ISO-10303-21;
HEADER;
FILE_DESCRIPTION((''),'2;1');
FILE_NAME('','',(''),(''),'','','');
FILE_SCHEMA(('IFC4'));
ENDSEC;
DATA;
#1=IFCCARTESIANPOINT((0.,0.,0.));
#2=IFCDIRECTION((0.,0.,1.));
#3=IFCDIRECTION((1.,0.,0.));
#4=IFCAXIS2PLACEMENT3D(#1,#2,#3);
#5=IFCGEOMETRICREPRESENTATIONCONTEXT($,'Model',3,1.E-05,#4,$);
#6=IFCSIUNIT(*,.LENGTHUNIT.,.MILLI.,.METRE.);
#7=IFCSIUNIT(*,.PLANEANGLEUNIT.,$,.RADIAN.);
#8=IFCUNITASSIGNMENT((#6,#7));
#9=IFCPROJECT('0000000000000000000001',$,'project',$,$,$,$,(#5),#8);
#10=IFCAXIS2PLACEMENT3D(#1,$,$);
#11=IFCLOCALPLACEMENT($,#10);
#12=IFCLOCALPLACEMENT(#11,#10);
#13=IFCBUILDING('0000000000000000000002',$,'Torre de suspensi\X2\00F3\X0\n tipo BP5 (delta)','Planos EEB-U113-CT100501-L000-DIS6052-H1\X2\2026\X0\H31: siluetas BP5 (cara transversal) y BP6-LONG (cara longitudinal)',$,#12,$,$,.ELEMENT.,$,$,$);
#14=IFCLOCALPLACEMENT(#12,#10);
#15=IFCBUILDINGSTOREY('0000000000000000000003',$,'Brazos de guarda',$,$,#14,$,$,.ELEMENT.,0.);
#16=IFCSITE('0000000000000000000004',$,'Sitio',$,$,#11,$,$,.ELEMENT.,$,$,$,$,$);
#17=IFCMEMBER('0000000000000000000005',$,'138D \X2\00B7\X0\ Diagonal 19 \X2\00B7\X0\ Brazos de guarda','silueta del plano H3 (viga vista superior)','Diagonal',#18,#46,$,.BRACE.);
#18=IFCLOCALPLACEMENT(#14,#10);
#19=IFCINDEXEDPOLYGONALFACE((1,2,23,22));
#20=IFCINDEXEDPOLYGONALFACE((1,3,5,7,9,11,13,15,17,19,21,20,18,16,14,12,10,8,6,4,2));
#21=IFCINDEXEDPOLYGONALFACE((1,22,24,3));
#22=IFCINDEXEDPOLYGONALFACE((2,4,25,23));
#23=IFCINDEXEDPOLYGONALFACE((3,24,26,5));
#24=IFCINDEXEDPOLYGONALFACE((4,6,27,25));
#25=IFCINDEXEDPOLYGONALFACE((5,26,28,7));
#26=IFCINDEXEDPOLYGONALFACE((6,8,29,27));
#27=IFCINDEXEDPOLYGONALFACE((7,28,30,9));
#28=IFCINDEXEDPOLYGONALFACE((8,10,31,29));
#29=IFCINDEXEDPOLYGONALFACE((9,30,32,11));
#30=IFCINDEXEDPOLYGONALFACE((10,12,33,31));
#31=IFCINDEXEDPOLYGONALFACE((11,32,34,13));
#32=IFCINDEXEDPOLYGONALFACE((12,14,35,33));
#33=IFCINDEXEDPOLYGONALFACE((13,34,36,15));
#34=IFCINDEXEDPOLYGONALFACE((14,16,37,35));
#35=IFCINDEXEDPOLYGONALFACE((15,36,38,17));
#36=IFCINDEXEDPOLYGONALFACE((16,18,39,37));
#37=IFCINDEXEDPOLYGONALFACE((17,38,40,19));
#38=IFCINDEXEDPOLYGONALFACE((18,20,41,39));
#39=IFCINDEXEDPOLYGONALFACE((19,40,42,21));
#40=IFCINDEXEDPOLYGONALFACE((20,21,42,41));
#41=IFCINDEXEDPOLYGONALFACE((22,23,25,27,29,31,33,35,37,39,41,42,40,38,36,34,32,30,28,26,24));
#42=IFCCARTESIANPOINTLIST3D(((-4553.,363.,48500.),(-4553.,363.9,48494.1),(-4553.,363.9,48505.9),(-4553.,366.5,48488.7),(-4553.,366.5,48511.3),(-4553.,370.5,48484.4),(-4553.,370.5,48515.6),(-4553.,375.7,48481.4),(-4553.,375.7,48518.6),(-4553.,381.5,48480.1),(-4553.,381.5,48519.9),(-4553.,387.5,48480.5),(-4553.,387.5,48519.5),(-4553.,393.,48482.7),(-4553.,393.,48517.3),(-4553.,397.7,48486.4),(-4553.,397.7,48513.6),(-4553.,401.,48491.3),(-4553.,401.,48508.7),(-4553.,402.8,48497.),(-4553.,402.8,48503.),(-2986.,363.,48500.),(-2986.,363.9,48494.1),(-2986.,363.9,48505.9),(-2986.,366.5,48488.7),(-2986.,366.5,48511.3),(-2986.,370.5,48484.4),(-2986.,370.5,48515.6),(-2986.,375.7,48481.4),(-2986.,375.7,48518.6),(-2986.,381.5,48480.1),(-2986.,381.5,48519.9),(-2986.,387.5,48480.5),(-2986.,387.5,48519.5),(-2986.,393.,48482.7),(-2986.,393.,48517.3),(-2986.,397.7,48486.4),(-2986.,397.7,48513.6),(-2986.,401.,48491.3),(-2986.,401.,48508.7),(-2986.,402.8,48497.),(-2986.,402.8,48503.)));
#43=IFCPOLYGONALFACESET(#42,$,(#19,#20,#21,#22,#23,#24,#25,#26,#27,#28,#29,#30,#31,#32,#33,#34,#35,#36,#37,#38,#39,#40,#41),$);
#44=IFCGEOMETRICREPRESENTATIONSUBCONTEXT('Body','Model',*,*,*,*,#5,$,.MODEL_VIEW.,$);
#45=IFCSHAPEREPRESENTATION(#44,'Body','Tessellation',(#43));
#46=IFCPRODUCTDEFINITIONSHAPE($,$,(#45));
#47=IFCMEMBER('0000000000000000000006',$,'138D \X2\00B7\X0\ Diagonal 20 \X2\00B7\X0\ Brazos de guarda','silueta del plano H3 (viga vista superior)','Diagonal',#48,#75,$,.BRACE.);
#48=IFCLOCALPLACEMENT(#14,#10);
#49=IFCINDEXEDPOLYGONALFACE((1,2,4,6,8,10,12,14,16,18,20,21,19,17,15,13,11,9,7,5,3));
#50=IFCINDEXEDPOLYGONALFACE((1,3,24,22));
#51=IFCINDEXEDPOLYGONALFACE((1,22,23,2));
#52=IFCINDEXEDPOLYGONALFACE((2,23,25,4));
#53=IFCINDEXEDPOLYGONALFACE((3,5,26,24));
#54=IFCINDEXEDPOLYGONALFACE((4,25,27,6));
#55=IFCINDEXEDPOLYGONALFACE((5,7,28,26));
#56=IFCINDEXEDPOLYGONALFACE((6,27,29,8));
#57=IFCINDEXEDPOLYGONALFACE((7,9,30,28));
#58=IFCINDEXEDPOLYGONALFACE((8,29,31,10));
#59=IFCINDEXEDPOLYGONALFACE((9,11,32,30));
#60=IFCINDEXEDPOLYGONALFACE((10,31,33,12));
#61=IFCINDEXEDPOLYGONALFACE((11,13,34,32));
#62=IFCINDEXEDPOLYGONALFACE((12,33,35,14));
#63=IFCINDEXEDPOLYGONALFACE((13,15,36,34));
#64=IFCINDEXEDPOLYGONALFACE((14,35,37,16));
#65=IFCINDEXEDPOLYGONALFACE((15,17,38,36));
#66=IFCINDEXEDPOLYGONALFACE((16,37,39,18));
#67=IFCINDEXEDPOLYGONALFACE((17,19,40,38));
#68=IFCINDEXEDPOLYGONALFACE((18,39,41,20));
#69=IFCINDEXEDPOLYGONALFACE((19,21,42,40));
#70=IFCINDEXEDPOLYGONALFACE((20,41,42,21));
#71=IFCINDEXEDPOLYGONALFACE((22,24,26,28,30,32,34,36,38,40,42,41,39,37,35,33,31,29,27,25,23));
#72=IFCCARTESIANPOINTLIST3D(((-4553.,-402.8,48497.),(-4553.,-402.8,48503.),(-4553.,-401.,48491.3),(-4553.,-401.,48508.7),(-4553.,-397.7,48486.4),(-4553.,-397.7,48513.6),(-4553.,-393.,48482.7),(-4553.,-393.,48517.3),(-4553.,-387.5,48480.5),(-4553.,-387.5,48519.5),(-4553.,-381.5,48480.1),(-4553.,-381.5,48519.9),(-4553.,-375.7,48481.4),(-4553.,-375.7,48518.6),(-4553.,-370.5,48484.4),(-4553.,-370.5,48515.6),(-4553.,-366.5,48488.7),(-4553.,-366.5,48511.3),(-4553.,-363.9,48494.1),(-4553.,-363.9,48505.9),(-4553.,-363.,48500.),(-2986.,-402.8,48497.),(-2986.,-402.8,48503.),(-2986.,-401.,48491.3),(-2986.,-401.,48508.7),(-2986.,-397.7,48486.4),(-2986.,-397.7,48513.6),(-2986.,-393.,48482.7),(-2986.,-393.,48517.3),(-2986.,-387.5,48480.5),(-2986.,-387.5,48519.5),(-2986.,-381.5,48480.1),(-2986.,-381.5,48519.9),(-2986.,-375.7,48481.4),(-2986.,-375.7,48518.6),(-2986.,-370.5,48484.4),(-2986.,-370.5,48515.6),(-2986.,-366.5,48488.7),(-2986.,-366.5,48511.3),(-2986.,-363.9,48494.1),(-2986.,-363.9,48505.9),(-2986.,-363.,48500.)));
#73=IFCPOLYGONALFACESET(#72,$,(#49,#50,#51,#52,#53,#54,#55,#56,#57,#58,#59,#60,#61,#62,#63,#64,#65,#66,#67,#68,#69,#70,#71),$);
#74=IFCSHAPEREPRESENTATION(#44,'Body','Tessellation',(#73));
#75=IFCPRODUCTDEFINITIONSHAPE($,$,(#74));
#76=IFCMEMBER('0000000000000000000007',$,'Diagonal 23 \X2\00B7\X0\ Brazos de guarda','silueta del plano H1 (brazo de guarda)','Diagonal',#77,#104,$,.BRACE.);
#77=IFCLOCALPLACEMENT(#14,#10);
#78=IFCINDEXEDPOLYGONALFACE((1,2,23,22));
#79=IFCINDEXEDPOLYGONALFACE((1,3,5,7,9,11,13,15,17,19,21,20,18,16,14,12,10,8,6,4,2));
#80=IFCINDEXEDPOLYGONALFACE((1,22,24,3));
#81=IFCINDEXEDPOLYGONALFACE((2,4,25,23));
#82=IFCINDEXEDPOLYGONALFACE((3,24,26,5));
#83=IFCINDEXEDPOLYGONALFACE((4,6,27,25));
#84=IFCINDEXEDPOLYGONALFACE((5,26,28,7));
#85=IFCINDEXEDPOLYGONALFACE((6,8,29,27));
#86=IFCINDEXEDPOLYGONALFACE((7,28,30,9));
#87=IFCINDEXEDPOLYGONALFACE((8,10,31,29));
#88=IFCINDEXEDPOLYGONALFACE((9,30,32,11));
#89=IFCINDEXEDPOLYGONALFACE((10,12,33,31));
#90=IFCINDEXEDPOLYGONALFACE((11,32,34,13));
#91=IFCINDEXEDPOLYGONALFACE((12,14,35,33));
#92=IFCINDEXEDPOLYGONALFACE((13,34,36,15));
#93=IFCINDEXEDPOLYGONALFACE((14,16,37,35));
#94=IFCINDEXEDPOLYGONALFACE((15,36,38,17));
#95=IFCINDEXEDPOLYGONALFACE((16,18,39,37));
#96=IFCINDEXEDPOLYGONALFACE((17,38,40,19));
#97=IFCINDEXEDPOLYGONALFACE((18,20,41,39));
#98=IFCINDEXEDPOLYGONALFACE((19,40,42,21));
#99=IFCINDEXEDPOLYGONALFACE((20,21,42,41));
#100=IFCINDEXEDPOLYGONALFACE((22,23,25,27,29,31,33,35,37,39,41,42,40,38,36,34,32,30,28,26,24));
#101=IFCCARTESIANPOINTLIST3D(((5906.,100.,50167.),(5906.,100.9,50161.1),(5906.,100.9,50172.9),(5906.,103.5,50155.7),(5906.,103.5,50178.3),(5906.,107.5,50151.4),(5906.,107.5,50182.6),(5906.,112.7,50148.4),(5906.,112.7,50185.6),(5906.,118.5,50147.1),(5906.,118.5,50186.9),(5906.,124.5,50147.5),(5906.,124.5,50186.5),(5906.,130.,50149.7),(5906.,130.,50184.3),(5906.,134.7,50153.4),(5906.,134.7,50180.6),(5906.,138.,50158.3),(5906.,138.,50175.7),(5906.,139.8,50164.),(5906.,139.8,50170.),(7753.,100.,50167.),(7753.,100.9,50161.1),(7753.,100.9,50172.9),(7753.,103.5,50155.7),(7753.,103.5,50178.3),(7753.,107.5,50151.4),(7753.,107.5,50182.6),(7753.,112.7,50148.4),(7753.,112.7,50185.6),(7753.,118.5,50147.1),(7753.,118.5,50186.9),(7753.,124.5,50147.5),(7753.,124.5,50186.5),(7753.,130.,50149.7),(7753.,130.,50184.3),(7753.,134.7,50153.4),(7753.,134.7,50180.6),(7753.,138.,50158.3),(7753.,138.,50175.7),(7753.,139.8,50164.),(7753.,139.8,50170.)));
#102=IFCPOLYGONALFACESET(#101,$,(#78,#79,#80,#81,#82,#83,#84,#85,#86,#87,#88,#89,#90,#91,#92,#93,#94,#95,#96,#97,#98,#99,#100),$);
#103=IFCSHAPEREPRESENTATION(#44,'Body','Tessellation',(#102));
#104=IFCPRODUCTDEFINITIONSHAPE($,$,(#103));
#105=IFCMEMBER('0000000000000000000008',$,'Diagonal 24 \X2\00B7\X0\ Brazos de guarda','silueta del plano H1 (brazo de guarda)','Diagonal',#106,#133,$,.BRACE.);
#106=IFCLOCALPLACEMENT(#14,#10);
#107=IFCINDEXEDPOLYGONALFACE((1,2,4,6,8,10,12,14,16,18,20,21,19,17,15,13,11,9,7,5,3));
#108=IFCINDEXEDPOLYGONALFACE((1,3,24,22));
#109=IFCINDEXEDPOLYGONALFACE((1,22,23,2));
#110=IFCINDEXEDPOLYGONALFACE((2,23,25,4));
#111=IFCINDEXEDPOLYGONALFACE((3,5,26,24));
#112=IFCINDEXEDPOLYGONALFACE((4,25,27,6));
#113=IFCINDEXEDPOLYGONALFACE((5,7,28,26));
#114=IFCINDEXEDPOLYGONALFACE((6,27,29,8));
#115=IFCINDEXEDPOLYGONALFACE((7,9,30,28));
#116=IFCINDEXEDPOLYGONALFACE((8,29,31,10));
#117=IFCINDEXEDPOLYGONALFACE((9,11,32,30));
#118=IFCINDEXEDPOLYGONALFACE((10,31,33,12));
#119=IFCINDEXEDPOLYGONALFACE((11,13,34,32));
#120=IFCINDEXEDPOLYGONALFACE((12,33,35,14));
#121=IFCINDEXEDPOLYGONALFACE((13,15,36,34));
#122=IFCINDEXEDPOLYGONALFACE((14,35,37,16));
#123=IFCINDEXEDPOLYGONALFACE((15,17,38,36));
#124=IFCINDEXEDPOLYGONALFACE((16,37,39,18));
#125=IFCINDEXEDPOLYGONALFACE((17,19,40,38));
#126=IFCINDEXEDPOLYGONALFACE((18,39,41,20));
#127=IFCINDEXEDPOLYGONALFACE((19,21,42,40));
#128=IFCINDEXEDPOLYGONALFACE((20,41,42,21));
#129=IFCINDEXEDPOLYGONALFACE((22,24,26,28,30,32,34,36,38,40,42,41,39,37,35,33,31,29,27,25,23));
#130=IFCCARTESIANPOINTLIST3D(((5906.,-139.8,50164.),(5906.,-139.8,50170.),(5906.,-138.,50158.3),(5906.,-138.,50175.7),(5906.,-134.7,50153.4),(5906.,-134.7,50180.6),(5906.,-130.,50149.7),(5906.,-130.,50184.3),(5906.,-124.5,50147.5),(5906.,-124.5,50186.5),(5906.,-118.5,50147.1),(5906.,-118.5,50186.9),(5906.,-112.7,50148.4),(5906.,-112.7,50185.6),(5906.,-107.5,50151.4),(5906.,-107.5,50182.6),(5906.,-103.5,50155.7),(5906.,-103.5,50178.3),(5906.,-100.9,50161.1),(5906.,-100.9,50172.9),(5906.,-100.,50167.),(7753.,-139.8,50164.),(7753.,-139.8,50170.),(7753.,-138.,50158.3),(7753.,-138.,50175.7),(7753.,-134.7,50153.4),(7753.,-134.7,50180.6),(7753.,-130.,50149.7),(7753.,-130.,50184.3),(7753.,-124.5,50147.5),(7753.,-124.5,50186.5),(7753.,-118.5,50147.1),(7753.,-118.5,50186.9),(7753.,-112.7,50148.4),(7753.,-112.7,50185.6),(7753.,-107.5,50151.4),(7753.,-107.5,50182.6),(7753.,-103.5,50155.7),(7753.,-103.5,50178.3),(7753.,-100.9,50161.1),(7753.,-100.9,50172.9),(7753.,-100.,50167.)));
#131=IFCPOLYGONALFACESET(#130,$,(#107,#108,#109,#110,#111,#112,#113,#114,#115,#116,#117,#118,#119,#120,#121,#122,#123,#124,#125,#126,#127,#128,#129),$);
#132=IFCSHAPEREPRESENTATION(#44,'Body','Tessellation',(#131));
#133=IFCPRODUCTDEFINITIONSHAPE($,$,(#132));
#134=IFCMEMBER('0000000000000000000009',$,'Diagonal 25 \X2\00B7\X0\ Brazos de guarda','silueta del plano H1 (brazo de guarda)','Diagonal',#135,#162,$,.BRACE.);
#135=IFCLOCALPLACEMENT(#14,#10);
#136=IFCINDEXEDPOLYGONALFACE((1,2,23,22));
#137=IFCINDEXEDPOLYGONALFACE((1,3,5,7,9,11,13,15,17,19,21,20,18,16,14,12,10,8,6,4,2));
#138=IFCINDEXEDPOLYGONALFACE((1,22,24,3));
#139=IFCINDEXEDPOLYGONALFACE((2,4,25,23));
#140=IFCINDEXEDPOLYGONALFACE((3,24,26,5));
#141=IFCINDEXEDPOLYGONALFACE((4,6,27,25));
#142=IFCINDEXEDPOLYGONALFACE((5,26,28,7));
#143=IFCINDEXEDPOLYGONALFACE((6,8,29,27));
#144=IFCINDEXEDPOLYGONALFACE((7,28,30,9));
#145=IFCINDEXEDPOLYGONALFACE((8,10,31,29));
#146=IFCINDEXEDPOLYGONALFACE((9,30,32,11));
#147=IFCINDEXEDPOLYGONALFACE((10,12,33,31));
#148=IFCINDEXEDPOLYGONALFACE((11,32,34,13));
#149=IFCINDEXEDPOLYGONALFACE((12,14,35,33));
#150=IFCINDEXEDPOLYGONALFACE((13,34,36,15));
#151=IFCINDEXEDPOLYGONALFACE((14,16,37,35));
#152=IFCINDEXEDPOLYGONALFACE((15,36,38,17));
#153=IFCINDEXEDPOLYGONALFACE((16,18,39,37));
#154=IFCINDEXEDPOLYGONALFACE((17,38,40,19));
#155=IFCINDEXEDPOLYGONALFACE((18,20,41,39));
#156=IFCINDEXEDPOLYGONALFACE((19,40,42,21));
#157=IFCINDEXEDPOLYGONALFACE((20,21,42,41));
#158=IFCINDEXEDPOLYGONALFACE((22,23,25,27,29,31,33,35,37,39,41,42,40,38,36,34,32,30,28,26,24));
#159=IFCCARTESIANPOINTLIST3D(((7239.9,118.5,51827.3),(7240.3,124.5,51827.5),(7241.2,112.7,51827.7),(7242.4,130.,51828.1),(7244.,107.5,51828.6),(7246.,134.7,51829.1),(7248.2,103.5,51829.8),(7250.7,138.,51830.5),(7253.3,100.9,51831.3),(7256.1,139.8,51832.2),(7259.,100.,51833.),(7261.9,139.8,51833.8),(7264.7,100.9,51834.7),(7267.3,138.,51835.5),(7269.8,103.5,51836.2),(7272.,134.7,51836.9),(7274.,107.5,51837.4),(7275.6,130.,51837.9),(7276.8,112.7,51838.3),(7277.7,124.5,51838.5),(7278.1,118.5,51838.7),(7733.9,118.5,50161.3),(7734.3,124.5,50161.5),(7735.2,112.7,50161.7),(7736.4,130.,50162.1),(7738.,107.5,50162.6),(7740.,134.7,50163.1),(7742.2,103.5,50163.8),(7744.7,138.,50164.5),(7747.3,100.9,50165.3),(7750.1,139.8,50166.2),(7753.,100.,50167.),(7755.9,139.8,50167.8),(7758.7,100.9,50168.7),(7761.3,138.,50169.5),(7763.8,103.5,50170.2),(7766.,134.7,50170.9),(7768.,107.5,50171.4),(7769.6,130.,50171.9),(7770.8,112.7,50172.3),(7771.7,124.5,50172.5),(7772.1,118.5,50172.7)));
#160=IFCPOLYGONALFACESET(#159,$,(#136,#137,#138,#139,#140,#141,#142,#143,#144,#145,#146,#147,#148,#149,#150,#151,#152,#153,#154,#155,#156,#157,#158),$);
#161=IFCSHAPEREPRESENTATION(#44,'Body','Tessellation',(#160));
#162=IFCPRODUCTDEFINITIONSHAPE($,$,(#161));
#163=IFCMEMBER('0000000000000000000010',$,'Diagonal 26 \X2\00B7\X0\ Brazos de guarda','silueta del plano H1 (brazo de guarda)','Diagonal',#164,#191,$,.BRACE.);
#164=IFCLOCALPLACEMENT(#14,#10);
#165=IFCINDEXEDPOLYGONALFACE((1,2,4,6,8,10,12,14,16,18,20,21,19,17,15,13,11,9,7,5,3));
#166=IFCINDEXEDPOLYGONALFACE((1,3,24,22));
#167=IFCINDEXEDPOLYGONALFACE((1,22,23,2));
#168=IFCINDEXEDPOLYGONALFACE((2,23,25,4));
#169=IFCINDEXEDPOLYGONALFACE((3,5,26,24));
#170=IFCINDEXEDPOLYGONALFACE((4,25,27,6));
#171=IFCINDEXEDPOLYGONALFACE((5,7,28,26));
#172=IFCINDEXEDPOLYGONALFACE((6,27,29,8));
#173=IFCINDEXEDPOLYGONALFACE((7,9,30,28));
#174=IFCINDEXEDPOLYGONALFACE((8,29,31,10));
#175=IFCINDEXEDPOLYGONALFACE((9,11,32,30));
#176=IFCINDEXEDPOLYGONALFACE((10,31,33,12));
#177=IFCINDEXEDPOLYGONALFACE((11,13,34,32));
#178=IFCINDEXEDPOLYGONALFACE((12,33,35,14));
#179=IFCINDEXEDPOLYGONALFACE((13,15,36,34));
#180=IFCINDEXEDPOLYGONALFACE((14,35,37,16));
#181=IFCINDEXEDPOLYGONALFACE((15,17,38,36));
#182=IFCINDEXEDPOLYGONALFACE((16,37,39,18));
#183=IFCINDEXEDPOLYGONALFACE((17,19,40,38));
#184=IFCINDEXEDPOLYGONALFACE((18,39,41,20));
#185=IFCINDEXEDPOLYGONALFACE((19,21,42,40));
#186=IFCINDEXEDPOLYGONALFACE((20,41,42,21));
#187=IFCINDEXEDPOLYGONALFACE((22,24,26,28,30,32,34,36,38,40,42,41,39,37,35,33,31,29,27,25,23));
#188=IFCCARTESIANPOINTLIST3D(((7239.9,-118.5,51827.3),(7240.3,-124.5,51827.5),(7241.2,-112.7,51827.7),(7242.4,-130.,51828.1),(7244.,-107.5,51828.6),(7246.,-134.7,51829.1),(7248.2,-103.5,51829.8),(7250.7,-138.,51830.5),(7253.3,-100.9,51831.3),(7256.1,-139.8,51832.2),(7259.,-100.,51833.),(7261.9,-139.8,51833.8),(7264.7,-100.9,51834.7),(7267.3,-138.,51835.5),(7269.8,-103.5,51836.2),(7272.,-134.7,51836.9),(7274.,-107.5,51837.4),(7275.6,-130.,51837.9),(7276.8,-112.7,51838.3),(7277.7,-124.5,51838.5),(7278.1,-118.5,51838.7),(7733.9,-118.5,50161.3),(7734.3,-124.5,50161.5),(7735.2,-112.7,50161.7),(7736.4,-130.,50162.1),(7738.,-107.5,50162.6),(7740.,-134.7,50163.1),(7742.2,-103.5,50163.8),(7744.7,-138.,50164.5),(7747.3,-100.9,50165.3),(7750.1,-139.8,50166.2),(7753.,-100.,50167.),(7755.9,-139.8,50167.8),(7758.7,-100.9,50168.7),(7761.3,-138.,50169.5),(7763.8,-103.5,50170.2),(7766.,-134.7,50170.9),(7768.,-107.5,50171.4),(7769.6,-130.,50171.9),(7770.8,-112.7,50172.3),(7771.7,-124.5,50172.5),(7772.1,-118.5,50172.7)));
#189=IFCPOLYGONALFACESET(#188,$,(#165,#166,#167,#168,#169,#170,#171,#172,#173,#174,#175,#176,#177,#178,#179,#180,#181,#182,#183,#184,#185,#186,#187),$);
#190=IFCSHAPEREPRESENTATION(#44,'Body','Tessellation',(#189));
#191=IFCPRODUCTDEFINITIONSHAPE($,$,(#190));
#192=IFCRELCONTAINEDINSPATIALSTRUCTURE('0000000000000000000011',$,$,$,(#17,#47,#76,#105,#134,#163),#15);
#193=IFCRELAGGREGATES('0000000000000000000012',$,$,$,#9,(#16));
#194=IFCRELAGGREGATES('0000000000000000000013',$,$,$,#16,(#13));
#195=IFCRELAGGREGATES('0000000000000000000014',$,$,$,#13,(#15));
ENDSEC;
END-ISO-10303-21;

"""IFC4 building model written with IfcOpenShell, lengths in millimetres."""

from ifc_helpers import new_model, si_unit, frame, origin, origin_with_axes, place, context, subcontext, project, spatial, circle, extrude, element, save


model = new_model("IFC4")

# Units and contexts
model_context = context("Model", 3, precision=1e-05, world=origin_with_axes())
body_context = subcontext(model_context, "Body", "Model", "MODEL_VIEW")
ifc_project = project(units=[si_unit("LENGTHUNIT", "METRE", prefix="MILLI"), si_unit("PLANEANGLEUNIT", "RADIAN")], contexts=[model_context])

# Site, building, storey
site_placement = place(None, origin())
site = spatial("IfcSite", under=ifc_project, at=site_placement, Name="Sitio", CompositionType="ELEMENT")
building_placement = place(site_placement, origin())
building = spatial("IfcBuilding", under=site, at=building_placement, Name="Torre de suspensión tipo BP5 (delta)", Description="Planos EEB-U113-CT100501-L000-DIS6052-H1…H31: siluetas BP5 (cara transversal) y BP6-LONG (cara longitudinal)", CompositionType="ELEMENT")
storey_placement = place(building_placement, origin())
storey = spatial("IfcBuildingStorey", under=building, at=storey_placement, Name="Brazos de guarda", CompositionType="ELEMENT", Elevation=0.0)

# Members
for number, where, z_axis, x_axis, name in (
    (1, (-2986.0, 383.0, 48500.0), (-1.0, 0.0, 0.0), (0.0, -1.0, 0.0), "138D · Diagonal 19 · Brazos de guarda"),
    (2, (-2986.0, -383.0, 48500.0), (-1.0, 0.0, 0.0), (0.0, 1.0, 0.0), "138D · Diagonal 20 · Brazos de guarda"),
):
    element("IfcMember", number, at=place(storey_placement, frame(where, z_axis=z_axis, x_axis=x_axis)), inside=storey, Name=name, Description="silueta del plano H3 (viga vista superior)", ObjectType="Diagonal", PredefinedType="BRACE", context=body_context, shape_type="SweptSolid", body=[
        extrude(circle(Radius=20.0), None, (0.0, 0.0, 1.0), 1567.0),
    ])
for number, where, z_axis, x_axis, name in (
    (3, (5906.0, 120.0, 50167.0), (1.0, 0.0, 0.0), (0.0, -1.0, 0.0), "Diagonal 23 · Brazos de guarda"),
    (4, (5906.0, -120.0, 50167.0), (1.0, 0.0, 0.0), (0.0, 1.0, 0.0), "Diagonal 24 · Brazos de guarda"),
):
    element("IfcMember", number, at=place(storey_placement, frame(where, z_axis=z_axis, x_axis=x_axis)), inside=storey, Name=name, Description="silueta del plano H1 (brazo de guarda)", ObjectType="Diagonal", PredefinedType="BRACE", context=body_context, shape_type="SweptSolid", body=[
        extrude(circle(Radius=20.0), None, (0.0, 0.0, 1.0), 1847.0),
    ])
for number, where, z_axis, x_axis, name in (
    (5, (7753.0, 120.0, 50167.0), (-0.284284, 0.0, 0.95874), (0.0, -1.0, 0.0), "Diagonal 25 · Brazos de guarda"),
    (6, (7753.0, -120.0, 50167.0), (-0.284284, 0.0, 0.95874), (0.0, 1.0, 0.0), "Diagonal 26 · Brazos de guarda"),
):
    element("IfcMember", number, at=place(storey_placement, frame(where, z_axis=z_axis, x_axis=x_axis)), inside=storey, Name=name, Description="silueta del plano H1 (brazo de guarda)", ObjectType="Diagonal", PredefinedType="BRACE", context=body_context, shape_type="SweptSolid", body=[
        extrude(circle(Radius=20.0), None, (0.0, 0.0, 1.0), 1737.7),
    ])

save(model, "model.ifc")
